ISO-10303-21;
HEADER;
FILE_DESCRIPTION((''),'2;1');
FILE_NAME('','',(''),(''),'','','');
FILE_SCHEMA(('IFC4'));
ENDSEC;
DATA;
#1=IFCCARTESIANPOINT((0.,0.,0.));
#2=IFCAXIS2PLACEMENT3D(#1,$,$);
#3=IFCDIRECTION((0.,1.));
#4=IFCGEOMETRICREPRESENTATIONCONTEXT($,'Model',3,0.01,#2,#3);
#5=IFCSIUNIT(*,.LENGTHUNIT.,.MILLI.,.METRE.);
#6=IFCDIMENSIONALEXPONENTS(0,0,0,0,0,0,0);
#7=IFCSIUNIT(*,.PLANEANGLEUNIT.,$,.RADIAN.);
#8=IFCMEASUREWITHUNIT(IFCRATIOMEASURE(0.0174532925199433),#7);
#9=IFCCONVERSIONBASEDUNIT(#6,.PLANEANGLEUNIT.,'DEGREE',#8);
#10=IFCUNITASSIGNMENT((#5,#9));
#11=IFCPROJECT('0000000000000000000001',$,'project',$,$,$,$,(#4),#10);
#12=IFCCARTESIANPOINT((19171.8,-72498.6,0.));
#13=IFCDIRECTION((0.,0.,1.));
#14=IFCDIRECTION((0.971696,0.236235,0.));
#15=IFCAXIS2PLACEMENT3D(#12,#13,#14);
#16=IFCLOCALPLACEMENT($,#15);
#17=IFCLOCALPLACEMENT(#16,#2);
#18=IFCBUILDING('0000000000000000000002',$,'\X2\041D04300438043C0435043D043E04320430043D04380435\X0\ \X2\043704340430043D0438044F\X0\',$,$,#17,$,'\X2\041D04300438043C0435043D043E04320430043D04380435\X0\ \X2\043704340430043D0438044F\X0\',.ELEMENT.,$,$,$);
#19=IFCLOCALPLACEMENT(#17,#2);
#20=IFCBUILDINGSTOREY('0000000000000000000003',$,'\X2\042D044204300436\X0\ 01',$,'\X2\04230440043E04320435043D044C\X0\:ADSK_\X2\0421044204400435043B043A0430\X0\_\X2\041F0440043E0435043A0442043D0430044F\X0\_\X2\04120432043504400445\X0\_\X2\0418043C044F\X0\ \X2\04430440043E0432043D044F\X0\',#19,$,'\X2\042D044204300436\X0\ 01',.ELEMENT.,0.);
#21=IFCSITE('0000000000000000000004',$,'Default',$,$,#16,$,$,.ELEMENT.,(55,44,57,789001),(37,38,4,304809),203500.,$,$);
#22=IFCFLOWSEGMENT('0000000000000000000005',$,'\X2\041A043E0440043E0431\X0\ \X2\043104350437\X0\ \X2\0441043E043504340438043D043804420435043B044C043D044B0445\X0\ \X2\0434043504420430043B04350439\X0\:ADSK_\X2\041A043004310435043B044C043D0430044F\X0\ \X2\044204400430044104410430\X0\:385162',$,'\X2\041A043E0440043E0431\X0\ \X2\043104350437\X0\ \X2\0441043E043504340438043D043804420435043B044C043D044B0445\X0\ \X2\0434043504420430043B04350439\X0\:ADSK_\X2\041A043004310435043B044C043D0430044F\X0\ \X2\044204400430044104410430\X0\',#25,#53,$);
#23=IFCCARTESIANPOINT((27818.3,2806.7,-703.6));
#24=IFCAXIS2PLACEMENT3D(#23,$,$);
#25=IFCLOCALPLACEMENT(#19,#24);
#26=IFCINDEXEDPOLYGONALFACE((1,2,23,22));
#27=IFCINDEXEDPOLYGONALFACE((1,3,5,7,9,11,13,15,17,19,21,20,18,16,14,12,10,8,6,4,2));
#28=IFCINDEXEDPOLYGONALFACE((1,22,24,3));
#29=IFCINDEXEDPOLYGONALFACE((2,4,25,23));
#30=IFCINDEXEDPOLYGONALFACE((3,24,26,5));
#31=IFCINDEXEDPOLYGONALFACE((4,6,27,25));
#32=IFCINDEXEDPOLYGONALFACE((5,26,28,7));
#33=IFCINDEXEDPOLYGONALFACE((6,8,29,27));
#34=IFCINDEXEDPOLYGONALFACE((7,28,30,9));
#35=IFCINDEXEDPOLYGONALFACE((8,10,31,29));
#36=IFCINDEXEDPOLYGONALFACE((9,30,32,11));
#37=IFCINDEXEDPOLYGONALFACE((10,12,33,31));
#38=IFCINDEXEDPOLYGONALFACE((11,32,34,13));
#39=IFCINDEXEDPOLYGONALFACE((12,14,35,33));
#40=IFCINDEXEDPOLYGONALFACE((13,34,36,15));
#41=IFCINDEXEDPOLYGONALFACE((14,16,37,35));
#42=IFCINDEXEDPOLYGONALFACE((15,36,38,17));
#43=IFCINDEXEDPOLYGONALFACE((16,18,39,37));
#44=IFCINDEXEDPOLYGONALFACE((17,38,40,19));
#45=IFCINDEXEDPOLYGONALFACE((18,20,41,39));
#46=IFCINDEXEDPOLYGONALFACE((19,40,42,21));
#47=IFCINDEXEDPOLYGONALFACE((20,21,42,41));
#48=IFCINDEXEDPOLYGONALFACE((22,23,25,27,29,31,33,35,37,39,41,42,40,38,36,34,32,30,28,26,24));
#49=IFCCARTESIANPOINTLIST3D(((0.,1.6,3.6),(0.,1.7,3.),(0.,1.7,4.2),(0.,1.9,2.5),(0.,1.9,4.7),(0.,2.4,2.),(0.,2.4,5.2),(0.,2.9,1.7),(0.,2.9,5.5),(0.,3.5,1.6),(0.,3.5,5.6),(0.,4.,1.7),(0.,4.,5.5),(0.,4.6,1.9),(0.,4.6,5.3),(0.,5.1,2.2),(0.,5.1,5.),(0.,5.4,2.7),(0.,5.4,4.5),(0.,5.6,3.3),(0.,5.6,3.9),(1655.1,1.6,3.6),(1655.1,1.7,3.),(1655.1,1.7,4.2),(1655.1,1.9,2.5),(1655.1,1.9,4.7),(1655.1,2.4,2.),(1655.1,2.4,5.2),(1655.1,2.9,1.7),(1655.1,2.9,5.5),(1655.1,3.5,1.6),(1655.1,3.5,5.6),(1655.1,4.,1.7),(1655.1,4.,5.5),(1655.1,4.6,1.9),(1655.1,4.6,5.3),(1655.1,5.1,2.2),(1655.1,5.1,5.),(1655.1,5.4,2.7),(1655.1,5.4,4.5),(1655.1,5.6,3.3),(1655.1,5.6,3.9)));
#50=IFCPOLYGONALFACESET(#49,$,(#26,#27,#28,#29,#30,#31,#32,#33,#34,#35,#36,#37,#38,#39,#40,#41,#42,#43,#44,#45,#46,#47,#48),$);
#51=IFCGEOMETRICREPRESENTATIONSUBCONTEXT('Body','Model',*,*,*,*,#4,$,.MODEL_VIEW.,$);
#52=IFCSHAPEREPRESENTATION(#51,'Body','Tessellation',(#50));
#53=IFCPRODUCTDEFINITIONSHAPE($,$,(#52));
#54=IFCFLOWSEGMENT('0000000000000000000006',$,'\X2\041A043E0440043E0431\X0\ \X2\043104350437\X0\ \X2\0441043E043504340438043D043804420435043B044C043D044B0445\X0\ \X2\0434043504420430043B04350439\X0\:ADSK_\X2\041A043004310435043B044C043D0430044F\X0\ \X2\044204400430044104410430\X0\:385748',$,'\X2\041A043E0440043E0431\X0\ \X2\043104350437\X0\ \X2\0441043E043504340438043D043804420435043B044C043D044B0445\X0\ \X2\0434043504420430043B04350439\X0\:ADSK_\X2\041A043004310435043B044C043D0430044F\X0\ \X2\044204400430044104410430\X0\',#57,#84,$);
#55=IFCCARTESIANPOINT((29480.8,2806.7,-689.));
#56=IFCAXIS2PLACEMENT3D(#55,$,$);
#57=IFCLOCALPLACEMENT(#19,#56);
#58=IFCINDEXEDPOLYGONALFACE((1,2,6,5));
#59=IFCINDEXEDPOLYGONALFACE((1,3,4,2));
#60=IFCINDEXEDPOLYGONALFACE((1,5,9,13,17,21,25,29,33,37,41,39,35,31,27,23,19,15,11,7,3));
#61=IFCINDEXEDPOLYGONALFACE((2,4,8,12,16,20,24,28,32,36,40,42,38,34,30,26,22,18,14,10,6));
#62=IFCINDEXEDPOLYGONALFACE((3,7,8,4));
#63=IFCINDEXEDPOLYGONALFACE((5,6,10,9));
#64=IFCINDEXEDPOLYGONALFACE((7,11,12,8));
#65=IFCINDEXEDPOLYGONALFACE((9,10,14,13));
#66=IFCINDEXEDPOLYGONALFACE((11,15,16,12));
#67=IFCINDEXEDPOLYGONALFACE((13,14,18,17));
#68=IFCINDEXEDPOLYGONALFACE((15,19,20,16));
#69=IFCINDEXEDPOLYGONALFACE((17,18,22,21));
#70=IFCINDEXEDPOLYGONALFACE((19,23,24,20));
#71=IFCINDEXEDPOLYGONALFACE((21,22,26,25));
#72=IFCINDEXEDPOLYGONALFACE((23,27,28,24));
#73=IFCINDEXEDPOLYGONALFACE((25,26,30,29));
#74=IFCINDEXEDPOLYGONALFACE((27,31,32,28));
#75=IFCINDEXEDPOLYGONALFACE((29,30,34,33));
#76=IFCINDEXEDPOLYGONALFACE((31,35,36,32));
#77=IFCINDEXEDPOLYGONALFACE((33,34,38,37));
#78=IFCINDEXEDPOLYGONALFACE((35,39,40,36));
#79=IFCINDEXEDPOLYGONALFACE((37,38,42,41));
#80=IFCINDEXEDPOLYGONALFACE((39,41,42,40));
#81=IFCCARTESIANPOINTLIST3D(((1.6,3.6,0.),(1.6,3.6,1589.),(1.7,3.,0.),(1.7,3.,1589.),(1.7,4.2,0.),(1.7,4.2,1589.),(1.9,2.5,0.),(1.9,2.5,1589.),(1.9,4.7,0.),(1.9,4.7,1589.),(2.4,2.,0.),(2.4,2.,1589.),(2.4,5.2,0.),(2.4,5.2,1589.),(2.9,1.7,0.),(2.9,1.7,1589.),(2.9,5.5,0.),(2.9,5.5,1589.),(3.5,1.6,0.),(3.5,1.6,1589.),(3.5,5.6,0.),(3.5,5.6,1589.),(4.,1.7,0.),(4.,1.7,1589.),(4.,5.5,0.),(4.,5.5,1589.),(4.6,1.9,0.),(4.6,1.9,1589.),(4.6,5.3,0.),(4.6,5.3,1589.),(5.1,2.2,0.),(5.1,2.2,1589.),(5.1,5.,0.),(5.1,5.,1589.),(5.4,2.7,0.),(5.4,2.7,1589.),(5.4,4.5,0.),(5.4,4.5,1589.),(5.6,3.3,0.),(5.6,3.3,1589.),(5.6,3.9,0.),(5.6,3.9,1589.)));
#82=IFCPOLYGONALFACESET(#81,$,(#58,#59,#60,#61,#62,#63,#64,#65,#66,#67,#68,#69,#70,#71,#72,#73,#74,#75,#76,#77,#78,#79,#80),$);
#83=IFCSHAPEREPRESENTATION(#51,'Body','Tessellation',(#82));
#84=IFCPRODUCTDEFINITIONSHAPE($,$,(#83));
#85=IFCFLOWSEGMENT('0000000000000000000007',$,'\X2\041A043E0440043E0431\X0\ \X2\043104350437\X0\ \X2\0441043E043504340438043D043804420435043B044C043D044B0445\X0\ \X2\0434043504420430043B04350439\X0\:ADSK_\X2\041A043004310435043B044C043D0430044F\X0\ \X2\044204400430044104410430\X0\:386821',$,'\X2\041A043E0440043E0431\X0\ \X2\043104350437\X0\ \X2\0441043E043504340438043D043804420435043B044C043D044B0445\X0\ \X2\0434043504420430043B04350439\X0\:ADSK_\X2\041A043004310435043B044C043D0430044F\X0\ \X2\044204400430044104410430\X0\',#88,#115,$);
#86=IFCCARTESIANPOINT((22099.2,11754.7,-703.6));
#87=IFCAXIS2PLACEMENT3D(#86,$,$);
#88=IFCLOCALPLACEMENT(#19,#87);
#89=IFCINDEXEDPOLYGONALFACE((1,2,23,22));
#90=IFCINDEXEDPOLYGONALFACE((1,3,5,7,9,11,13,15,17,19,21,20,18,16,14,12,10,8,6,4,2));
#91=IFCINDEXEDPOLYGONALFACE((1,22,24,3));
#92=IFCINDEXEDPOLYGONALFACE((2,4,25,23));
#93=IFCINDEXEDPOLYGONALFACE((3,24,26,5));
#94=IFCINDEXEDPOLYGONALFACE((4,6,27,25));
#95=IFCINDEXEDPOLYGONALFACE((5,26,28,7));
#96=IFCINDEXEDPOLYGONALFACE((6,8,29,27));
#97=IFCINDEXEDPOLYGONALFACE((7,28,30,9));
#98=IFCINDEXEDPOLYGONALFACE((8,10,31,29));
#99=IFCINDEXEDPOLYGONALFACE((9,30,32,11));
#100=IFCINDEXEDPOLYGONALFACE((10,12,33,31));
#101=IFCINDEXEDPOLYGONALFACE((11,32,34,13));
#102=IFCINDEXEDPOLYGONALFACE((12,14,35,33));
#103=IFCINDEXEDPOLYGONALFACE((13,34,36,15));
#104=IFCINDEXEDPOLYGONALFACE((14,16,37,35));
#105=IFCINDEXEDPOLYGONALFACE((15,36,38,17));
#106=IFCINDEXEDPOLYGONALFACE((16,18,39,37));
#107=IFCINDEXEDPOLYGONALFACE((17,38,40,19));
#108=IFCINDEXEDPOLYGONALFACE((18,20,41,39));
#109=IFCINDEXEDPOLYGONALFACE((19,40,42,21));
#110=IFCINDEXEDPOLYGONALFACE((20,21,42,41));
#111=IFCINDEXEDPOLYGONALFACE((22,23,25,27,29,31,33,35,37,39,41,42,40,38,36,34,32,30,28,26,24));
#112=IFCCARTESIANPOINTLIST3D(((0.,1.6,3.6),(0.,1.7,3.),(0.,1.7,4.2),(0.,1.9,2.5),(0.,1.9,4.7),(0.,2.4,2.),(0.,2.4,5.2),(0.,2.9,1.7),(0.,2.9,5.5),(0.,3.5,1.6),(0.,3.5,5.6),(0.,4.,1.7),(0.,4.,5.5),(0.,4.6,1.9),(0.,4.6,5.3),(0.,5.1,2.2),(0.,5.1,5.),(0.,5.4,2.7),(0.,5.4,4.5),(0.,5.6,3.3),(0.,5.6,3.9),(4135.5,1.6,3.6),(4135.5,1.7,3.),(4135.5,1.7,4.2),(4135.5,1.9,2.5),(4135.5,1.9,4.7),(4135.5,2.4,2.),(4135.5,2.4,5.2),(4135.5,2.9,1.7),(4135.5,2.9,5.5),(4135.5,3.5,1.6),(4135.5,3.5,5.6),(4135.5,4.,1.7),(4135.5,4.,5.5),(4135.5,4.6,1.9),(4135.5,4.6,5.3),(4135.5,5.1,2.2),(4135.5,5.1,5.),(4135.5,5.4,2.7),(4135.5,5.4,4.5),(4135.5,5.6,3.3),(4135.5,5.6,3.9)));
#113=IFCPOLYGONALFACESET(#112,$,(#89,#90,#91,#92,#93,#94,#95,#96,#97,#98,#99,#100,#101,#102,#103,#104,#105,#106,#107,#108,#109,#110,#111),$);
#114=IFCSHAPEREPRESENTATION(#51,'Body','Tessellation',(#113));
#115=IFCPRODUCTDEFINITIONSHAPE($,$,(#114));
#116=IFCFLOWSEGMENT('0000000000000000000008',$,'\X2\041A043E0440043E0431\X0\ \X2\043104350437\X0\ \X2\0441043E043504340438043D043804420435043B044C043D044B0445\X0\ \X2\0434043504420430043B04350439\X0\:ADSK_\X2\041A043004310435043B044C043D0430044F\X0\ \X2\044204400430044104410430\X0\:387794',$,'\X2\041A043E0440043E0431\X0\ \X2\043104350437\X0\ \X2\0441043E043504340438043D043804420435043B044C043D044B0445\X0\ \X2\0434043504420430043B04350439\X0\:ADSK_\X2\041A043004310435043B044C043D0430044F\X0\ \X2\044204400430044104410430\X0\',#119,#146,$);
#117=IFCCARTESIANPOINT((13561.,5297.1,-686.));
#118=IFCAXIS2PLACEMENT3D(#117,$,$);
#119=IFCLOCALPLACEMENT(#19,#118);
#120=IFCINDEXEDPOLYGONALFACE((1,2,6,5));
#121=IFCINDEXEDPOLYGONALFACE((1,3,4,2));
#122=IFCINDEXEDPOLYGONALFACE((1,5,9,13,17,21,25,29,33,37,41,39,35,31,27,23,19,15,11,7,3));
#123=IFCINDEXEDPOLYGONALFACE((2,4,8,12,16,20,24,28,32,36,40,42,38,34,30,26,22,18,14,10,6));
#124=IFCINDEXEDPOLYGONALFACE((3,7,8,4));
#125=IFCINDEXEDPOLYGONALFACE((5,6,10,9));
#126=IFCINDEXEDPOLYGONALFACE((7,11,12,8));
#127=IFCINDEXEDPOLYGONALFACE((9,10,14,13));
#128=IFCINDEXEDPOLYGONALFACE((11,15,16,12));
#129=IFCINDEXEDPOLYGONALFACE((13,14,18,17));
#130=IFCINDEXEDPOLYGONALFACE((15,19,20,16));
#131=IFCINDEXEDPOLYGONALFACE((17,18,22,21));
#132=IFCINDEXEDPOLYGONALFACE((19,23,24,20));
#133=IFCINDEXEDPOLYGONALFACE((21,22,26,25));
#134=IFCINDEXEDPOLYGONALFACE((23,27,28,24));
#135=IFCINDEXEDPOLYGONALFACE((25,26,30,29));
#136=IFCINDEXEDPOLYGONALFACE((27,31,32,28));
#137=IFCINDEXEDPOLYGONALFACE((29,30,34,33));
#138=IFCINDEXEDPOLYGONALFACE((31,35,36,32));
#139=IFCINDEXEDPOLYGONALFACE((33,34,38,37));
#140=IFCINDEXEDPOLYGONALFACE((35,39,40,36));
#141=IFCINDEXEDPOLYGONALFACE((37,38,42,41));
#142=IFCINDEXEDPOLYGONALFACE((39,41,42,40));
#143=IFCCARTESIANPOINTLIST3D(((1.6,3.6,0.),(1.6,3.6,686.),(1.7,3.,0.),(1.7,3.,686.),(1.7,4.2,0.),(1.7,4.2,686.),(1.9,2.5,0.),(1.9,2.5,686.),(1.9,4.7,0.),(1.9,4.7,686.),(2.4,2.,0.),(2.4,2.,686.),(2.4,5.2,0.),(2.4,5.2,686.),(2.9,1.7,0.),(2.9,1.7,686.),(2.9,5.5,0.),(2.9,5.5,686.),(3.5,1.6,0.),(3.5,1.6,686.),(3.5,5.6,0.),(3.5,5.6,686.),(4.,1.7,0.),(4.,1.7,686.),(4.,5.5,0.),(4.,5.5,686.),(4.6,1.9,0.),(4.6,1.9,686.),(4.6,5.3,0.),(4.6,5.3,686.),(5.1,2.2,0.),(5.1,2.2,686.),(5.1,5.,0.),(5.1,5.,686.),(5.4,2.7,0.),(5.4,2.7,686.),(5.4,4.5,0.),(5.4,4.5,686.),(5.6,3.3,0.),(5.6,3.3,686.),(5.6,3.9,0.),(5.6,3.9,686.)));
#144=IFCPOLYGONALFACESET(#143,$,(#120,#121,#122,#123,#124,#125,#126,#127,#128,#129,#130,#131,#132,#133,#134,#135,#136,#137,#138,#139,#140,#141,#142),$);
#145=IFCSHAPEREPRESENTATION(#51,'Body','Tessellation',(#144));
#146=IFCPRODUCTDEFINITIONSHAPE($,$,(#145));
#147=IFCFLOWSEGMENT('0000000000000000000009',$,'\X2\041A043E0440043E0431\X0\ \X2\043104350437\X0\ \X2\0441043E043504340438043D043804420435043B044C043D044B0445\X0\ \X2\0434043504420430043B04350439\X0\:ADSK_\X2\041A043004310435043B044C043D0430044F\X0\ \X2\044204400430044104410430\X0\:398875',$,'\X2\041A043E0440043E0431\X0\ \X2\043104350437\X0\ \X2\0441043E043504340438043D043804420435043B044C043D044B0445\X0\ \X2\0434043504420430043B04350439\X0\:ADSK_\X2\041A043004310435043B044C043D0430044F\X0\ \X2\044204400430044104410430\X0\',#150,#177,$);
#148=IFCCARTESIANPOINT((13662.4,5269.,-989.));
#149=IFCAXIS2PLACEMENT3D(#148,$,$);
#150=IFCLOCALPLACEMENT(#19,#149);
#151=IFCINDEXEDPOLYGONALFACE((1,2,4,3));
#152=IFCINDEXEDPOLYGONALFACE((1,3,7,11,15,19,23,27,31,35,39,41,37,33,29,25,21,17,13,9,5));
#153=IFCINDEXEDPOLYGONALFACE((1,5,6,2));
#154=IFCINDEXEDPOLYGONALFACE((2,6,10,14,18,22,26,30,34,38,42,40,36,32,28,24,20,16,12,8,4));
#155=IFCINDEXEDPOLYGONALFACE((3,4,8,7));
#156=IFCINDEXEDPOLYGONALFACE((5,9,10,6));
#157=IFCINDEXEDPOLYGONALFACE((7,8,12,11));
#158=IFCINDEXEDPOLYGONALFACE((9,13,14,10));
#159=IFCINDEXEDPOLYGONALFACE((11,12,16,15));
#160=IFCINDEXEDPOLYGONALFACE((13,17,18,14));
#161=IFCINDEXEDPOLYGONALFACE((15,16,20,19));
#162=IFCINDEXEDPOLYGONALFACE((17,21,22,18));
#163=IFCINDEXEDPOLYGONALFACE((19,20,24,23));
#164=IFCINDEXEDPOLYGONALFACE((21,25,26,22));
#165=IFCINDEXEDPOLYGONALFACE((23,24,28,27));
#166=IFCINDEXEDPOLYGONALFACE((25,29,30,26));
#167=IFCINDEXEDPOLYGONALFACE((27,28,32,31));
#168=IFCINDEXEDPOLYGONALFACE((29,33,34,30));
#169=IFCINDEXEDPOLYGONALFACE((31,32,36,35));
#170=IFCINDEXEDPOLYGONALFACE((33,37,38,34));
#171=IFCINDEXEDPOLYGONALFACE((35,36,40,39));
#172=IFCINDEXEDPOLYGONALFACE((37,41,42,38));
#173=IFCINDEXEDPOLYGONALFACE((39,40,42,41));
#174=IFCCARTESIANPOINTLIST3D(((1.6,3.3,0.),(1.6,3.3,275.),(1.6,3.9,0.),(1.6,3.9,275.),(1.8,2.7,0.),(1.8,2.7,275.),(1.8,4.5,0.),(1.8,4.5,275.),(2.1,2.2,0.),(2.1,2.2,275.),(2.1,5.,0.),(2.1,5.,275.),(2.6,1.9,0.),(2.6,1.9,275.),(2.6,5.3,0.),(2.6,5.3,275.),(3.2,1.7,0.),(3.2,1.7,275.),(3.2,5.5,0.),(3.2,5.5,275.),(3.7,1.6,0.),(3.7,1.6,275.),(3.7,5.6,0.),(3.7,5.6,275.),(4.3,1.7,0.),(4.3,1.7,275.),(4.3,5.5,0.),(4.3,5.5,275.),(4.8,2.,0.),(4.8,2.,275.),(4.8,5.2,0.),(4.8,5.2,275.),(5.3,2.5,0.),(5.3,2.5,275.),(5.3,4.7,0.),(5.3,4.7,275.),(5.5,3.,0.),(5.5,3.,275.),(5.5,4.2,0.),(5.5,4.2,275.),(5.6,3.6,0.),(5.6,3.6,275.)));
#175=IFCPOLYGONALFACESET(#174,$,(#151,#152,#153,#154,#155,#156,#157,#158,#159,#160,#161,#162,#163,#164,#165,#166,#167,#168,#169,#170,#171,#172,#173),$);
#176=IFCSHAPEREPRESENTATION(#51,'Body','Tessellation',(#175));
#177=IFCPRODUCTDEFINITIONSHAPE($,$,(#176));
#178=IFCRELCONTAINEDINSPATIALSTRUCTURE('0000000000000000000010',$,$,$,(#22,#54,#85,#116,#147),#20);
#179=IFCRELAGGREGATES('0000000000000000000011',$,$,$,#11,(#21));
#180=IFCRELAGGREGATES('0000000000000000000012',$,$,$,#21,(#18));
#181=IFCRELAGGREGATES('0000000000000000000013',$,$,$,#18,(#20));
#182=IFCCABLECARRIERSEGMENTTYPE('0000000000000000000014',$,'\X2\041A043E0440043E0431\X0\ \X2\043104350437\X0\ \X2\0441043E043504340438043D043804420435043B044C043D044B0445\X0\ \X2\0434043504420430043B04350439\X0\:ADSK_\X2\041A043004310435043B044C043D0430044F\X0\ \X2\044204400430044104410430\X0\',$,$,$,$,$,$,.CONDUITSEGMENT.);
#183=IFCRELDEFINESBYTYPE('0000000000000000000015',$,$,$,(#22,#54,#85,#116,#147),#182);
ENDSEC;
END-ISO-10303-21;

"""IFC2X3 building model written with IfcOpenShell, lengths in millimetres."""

from ifc_helpers import new_model, entity, si_unit, converted_unit, direction, frame, origin, origin_2d_with_axis, place, context, subcontext, project, spatial, circle, extrude, type_object, element, save


model = new_model("IFC2X3")

# Units and contexts
model_context = context("Model", 3, precision=0.01, world=origin(), true_north=direction((0.0, 1.0)))
body_context = subcontext(model_context, "Body", "Model", "MODEL_VIEW")
ifc_project = project(units=[si_unit("LENGTHUNIT", "METRE", prefix="MILLI"), converted_unit("PLANEANGLEUNIT", "DEGREE", entity("IfcRatioMeasure", 0.0174532925199433), si_unit("PLANEANGLEUNIT", "RADIAN"), dimensions=[0, 0, 0, 0, 0, 0, 0])], contexts=[model_context])

# Site, building, storey
site_placement = place(None, frame((19171.8, -72498.6, 0.0), z_axis=(0.0, 0.0, 1.0), x_axis=(0.971696, 0.236235, 0.0)))
site = spatial("IfcSite", under=ifc_project, at=site_placement, Name="Default", CompositionType="ELEMENT", RefLatitude=(55, 44, 57, 789001), RefLongitude=(37, 38, 4, 304809), RefElevation=203500.0)
building_placement = place(site_placement, origin())
building = spatial("IfcBuilding", under=site, at=building_placement, Name="Наименование здания", LongName="Наименование здания", CompositionType="ELEMENT")
storey_placement = place(building_placement, origin())
storey = spatial("IfcBuildingStorey", under=building, at=storey_placement, Name="Этаж 01", ObjectType="Уровень:ADSK_Стрелка_Проектная_Вверх_Имя уровня", LongName="Этаж 01", CompositionType="ELEMENT", Elevation=0.0)

# Flow segments
cable_carrier_segment_type_1 = type_object("IfcCableCarrierSegmentType", Name="Короб без соединительных деталей:ADSK_Кабельная трасса", PredefinedType="CONDUITSEGMENT")
flow_segment_1_placement = place(storey_placement, frame((27818.3, 2806.7, -703.6)))
element("IfcFlowSegment", 1, at=flow_segment_1_placement, inside=storey, type_object=cable_carrier_segment_type_1, Name="Короб без соединительных деталей:ADSK_Кабельная трасса:385162", ObjectType="Короб без соединительных деталей:ADSK_Кабельная трасса", context=body_context, shape_type="SweptSolid", body=[
    extrude(circle(Radius=2.0, at=origin_2d_with_axis()), frame((0.0, 3.6, 3.6), z_axis=(1.0, 0.0, 0.0), x_axis=(0.0, -1.0, 0.0)), (0.0, 0.0, 1.0), 1655.1),
])
flow_segment_2_placement = place(storey_placement, frame((29480.8, 2806.7, -689.0)))
element("IfcFlowSegment", 2, at=flow_segment_2_placement, inside=storey, type_object=cable_carrier_segment_type_1, Name="Короб без соединительных деталей:ADSK_Кабельная трасса:385748", ObjectType="Короб без соединительных деталей:ADSK_Кабельная трасса", context=body_context, shape_type="SweptSolid", body=[
    extrude(circle(Radius=2.0, at=origin_2d_with_axis()), frame((3.6, 3.6, 0.0), z_axis=(0.0, 0.0, 1.0), x_axis=(-1.0, 0.0, 0.0)), (0.0, 0.0, 1.0), 1589.0),
])
flow_segment_3_placement = place(storey_placement, frame((22099.2, 11754.7, -703.6)))
element("IfcFlowSegment", 3, at=flow_segment_3_placement, inside=storey, type_object=cable_carrier_segment_type_1, Name="Короб без соединительных деталей:ADSK_Кабельная трасса:386821", ObjectType="Короб без соединительных деталей:ADSK_Кабельная трасса", context=body_context, shape_type="SweptSolid", body=[
    extrude(circle(Radius=2.0, at=origin_2d_with_axis()), frame((0.0, 3.6, 3.6), z_axis=(1.0, 0.0, 0.0), x_axis=(0.0, -1.0, 0.0)), (0.0, 0.0, 1.0), 4135.5),
])
flow_segment_4_placement = place(storey_placement, frame((13561.0, 5297.1, -686.0)))
element("IfcFlowSegment", 4, at=flow_segment_4_placement, inside=storey, type_object=cable_carrier_segment_type_1, Name="Короб без соединительных деталей:ADSK_Кабельная трасса:387794", ObjectType="Короб без соединительных деталей:ADSK_Кабельная трасса", context=body_context, shape_type="SweptSolid", body=[
    extrude(circle(Radius=2.0, at=origin_2d_with_axis()), frame((3.6, 3.6, 0.0), z_axis=(0.0, 0.0, 1.0), x_axis=(-1.0, 0.0, 0.0)), (0.0, 0.0, 1.0), 686.0),
])
flow_segment_5_placement = place(storey_placement, frame((13662.4, 5269.0, -989.0)))
element("IfcFlowSegment", 5, at=flow_segment_5_placement, inside=storey, type_object=cable_carrier_segment_type_1, Name="Короб без соединительных деталей:ADSK_Кабельная трасса:398875", ObjectType="Короб без соединительных деталей:ADSK_Кабельная трасса", context=body_context, shape_type="SweptSolid", body=[
    extrude(circle(Radius=2.0, at=origin_2d_with_axis()), frame((3.6, 3.6, 0.0)), (0.0, 0.0, 1.0), 275.0),
])

save(model, "model.ifc")
